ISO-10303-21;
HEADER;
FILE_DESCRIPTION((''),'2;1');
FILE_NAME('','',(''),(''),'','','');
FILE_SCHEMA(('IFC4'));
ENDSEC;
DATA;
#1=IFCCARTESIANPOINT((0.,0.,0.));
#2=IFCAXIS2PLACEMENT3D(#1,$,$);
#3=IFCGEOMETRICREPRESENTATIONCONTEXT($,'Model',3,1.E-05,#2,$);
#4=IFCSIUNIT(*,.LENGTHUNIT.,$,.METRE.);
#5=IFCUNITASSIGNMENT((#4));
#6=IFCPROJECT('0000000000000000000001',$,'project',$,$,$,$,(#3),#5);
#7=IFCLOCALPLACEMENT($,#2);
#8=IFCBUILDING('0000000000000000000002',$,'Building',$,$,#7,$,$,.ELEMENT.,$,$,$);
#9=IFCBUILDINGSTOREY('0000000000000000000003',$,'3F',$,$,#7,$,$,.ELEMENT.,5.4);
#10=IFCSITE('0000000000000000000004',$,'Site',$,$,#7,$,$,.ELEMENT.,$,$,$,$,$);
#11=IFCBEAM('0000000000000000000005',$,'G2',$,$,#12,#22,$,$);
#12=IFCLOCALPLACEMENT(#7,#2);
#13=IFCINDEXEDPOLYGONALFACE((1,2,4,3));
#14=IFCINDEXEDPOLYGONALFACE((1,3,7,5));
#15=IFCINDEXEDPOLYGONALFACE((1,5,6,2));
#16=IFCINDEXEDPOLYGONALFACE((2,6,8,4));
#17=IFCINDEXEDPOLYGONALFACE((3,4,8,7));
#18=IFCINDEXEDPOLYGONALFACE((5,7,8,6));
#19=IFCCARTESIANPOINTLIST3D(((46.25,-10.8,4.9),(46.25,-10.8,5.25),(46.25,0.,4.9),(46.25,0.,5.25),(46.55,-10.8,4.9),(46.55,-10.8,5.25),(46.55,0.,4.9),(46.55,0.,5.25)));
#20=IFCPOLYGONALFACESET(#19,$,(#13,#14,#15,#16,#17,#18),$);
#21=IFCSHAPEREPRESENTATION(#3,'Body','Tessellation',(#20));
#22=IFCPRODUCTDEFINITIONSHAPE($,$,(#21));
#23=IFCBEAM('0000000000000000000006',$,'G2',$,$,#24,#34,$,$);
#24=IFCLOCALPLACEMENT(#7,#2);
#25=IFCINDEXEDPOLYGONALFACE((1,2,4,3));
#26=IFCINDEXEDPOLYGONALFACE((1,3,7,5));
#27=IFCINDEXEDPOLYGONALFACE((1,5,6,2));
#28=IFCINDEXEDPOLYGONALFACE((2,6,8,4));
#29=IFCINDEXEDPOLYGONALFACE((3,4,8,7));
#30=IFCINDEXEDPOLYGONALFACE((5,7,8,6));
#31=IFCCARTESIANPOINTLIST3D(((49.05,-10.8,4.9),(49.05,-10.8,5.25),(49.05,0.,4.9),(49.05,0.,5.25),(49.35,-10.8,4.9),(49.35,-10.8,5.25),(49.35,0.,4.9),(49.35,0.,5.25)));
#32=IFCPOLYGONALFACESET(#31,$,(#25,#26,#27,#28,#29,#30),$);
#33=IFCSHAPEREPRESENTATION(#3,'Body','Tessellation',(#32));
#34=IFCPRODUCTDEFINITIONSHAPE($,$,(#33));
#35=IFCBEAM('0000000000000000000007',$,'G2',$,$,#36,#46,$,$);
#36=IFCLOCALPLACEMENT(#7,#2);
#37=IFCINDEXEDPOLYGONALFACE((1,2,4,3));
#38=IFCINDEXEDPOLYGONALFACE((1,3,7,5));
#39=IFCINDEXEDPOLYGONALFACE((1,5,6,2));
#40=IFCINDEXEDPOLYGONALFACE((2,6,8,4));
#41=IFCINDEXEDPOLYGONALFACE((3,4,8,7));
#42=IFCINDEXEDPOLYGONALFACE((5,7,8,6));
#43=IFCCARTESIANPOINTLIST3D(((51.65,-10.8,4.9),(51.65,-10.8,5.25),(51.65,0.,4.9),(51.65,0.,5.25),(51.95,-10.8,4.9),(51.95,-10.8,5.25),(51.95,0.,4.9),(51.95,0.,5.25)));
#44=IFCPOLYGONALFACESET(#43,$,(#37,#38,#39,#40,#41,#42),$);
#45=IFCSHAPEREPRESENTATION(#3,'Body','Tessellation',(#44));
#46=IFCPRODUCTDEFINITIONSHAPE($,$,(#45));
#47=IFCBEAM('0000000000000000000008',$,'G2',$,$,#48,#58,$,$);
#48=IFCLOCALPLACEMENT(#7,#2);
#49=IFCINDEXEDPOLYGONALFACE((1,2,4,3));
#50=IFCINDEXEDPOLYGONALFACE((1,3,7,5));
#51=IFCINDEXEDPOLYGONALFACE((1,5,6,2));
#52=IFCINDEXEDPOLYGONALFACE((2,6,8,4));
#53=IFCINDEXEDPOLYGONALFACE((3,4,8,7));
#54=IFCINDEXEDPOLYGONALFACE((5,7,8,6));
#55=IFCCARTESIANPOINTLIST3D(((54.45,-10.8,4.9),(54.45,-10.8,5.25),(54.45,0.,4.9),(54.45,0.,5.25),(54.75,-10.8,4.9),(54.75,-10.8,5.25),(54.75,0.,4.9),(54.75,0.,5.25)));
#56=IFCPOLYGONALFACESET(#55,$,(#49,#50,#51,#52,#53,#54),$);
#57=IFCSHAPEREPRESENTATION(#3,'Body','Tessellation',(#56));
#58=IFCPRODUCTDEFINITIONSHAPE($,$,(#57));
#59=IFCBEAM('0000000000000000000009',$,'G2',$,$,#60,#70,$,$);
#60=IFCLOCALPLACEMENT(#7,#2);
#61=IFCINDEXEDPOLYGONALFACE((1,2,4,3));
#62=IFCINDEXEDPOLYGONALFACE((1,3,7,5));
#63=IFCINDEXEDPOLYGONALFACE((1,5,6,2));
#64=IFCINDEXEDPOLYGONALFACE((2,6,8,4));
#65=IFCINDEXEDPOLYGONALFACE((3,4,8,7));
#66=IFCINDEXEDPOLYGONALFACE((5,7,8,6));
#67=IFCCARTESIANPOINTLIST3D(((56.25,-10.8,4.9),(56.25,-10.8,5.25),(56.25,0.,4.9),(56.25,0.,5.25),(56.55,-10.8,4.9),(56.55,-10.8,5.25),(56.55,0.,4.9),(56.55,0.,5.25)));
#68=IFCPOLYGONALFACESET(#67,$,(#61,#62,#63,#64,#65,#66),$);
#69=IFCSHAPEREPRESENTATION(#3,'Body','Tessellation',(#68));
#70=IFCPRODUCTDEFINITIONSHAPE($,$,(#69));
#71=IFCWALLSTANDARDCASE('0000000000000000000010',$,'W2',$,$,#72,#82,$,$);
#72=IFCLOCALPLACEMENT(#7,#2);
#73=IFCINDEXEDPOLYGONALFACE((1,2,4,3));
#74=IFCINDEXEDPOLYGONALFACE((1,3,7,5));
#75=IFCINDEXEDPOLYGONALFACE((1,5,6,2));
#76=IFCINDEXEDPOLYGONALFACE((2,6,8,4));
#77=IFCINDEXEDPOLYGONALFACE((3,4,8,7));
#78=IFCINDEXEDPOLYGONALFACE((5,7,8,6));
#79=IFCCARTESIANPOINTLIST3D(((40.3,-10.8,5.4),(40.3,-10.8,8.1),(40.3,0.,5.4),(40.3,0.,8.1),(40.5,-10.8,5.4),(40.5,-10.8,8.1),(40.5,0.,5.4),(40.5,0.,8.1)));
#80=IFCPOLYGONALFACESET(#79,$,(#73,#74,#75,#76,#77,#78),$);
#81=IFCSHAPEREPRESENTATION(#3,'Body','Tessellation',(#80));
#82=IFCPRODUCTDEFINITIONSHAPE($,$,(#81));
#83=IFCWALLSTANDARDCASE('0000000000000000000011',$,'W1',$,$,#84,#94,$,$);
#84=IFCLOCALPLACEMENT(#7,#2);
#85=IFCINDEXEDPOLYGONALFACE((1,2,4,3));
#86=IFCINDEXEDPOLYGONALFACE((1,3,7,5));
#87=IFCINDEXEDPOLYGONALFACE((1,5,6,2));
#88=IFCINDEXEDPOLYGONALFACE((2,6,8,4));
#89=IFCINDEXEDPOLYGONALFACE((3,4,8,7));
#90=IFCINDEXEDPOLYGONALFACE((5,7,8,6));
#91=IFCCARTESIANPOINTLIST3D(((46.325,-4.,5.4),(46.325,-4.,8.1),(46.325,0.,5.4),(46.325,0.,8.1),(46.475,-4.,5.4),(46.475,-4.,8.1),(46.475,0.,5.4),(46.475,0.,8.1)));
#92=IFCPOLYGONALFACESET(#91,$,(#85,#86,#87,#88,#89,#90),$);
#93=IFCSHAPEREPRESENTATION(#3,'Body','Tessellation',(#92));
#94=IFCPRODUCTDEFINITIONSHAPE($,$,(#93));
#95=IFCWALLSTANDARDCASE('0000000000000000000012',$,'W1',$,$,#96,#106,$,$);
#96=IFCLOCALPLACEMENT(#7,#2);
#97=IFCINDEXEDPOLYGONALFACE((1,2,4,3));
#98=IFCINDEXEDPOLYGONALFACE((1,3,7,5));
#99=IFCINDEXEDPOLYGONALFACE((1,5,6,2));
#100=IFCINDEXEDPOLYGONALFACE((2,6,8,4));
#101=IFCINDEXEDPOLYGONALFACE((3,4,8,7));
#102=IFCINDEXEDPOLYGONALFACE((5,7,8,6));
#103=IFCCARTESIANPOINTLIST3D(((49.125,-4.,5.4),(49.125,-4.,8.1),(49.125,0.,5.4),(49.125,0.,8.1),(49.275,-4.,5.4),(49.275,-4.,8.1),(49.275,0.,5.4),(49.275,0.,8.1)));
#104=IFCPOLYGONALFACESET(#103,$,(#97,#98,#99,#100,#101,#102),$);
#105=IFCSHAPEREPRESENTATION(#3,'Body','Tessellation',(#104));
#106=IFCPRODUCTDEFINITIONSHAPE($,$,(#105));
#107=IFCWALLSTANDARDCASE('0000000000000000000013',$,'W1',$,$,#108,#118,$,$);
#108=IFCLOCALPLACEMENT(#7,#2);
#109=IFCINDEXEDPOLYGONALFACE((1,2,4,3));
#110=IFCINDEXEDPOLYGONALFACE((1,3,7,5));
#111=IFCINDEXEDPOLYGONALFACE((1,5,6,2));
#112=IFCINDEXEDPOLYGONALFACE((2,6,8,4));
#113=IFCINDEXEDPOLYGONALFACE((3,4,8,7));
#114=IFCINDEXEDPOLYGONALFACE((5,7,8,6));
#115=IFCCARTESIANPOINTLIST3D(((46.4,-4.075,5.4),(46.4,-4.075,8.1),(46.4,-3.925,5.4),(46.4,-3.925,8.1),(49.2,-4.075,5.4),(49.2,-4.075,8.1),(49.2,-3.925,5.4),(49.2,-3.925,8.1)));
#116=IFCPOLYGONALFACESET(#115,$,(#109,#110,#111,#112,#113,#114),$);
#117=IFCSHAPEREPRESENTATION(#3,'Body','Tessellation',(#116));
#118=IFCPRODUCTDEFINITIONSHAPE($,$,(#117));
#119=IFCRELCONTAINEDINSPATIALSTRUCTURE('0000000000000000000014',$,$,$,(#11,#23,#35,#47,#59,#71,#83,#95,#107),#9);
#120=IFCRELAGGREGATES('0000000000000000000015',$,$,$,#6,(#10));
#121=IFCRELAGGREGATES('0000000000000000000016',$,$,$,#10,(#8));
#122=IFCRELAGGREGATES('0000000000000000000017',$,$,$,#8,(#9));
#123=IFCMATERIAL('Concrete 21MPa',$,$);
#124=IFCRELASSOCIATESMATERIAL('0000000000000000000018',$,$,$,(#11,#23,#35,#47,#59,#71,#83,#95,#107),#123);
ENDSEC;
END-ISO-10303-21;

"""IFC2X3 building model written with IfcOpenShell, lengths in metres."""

from ifc_helpers import new_model, si_unit, frame, origin, origin_2d, place, context, project, spatial, rectangle, extrude, material, element, save


model = new_model("IFC2X3")

# Units and contexts
model_context = context("Model", 3, precision=1e-05, world=origin())
ifc_project = project(units=[si_unit("LENGTHUNIT", "METRE")], contexts=[model_context])

# Site, building, storey
placement = place(None, origin())
site = spatial("IfcSite", under=ifc_project, at=placement, Name="Site", CompositionType="ELEMENT")
building = spatial("IfcBuilding", under=site, at=placement, Name="Building", CompositionType="ELEMENT")
storey = spatial("IfcBuildingStorey", under=building, at=placement, Name="3F", CompositionType="ELEMENT", Elevation=5.4)

# Shared definitions
ifc_material = material(Name="Concrete 21MPa")

# Beams
for number, where, name in (
    (1, (46.4, -5.4, 4.9), "G2"),
    (2, (49.2, -5.4, 4.9), "G2"),
    (3, (51.8, -5.4, 4.9), "G2"),
    (4, (54.6, -5.4, 4.9), "G2"),
    (5, (56.4, -5.4, 4.9), "G2"),
):
    element("IfcBeam", number, at=place(None, frame(where)), inside=storey, material=ifc_material, Name=name, context=model_context, shape_type="SweptSolid", body=[
        extrude(rectangle(XDim=0.3, YDim=10.8, at=origin_2d()), origin(), (0.0, 0.0, 1.0), 0.35),
    ])

# Walls
wall_1_placement = place(None, frame((40.4, -5.4, 5.4)))
element("IfcWallStandardCase", 6, at=wall_1_placement, inside=storey, material=ifc_material, Name="W2", context=model_context, shape_type="SweptSolid", body=[
    extrude(rectangle(XDim=0.2, YDim=10.8, at=origin_2d()), origin(), (0.0, 0.0, 1.0), 2.7),
])
for number, where, name in (
    (7, (46.4, -2.0, 5.4), "W1"),
    (8, (49.2, -2.0, 5.4), "W1"),
):
    element("IfcWallStandardCase", number, at=place(None, frame(where)), inside=storey, material=ifc_material, Name=name, context=model_context, shape_type="SweptSolid", body=[
        extrude(rectangle(XDim=0.15, YDim=4.0, at=origin_2d()), origin(), (0.0, 0.0, 1.0), 2.7),
    ])
wall_2_placement = place(None, frame((47.8, -4.0, 5.4)))
element("IfcWallStandardCase", 9, at=wall_2_placement, inside=storey, material=ifc_material, Name="W1", context=model_context, shape_type="SweptSolid", body=[
    extrude(rectangle(XDim=2.8, YDim=0.15, at=origin_2d()), origin(), (0.0, 0.0, 1.0), 2.7),
])

save(model, "model.ifc")
